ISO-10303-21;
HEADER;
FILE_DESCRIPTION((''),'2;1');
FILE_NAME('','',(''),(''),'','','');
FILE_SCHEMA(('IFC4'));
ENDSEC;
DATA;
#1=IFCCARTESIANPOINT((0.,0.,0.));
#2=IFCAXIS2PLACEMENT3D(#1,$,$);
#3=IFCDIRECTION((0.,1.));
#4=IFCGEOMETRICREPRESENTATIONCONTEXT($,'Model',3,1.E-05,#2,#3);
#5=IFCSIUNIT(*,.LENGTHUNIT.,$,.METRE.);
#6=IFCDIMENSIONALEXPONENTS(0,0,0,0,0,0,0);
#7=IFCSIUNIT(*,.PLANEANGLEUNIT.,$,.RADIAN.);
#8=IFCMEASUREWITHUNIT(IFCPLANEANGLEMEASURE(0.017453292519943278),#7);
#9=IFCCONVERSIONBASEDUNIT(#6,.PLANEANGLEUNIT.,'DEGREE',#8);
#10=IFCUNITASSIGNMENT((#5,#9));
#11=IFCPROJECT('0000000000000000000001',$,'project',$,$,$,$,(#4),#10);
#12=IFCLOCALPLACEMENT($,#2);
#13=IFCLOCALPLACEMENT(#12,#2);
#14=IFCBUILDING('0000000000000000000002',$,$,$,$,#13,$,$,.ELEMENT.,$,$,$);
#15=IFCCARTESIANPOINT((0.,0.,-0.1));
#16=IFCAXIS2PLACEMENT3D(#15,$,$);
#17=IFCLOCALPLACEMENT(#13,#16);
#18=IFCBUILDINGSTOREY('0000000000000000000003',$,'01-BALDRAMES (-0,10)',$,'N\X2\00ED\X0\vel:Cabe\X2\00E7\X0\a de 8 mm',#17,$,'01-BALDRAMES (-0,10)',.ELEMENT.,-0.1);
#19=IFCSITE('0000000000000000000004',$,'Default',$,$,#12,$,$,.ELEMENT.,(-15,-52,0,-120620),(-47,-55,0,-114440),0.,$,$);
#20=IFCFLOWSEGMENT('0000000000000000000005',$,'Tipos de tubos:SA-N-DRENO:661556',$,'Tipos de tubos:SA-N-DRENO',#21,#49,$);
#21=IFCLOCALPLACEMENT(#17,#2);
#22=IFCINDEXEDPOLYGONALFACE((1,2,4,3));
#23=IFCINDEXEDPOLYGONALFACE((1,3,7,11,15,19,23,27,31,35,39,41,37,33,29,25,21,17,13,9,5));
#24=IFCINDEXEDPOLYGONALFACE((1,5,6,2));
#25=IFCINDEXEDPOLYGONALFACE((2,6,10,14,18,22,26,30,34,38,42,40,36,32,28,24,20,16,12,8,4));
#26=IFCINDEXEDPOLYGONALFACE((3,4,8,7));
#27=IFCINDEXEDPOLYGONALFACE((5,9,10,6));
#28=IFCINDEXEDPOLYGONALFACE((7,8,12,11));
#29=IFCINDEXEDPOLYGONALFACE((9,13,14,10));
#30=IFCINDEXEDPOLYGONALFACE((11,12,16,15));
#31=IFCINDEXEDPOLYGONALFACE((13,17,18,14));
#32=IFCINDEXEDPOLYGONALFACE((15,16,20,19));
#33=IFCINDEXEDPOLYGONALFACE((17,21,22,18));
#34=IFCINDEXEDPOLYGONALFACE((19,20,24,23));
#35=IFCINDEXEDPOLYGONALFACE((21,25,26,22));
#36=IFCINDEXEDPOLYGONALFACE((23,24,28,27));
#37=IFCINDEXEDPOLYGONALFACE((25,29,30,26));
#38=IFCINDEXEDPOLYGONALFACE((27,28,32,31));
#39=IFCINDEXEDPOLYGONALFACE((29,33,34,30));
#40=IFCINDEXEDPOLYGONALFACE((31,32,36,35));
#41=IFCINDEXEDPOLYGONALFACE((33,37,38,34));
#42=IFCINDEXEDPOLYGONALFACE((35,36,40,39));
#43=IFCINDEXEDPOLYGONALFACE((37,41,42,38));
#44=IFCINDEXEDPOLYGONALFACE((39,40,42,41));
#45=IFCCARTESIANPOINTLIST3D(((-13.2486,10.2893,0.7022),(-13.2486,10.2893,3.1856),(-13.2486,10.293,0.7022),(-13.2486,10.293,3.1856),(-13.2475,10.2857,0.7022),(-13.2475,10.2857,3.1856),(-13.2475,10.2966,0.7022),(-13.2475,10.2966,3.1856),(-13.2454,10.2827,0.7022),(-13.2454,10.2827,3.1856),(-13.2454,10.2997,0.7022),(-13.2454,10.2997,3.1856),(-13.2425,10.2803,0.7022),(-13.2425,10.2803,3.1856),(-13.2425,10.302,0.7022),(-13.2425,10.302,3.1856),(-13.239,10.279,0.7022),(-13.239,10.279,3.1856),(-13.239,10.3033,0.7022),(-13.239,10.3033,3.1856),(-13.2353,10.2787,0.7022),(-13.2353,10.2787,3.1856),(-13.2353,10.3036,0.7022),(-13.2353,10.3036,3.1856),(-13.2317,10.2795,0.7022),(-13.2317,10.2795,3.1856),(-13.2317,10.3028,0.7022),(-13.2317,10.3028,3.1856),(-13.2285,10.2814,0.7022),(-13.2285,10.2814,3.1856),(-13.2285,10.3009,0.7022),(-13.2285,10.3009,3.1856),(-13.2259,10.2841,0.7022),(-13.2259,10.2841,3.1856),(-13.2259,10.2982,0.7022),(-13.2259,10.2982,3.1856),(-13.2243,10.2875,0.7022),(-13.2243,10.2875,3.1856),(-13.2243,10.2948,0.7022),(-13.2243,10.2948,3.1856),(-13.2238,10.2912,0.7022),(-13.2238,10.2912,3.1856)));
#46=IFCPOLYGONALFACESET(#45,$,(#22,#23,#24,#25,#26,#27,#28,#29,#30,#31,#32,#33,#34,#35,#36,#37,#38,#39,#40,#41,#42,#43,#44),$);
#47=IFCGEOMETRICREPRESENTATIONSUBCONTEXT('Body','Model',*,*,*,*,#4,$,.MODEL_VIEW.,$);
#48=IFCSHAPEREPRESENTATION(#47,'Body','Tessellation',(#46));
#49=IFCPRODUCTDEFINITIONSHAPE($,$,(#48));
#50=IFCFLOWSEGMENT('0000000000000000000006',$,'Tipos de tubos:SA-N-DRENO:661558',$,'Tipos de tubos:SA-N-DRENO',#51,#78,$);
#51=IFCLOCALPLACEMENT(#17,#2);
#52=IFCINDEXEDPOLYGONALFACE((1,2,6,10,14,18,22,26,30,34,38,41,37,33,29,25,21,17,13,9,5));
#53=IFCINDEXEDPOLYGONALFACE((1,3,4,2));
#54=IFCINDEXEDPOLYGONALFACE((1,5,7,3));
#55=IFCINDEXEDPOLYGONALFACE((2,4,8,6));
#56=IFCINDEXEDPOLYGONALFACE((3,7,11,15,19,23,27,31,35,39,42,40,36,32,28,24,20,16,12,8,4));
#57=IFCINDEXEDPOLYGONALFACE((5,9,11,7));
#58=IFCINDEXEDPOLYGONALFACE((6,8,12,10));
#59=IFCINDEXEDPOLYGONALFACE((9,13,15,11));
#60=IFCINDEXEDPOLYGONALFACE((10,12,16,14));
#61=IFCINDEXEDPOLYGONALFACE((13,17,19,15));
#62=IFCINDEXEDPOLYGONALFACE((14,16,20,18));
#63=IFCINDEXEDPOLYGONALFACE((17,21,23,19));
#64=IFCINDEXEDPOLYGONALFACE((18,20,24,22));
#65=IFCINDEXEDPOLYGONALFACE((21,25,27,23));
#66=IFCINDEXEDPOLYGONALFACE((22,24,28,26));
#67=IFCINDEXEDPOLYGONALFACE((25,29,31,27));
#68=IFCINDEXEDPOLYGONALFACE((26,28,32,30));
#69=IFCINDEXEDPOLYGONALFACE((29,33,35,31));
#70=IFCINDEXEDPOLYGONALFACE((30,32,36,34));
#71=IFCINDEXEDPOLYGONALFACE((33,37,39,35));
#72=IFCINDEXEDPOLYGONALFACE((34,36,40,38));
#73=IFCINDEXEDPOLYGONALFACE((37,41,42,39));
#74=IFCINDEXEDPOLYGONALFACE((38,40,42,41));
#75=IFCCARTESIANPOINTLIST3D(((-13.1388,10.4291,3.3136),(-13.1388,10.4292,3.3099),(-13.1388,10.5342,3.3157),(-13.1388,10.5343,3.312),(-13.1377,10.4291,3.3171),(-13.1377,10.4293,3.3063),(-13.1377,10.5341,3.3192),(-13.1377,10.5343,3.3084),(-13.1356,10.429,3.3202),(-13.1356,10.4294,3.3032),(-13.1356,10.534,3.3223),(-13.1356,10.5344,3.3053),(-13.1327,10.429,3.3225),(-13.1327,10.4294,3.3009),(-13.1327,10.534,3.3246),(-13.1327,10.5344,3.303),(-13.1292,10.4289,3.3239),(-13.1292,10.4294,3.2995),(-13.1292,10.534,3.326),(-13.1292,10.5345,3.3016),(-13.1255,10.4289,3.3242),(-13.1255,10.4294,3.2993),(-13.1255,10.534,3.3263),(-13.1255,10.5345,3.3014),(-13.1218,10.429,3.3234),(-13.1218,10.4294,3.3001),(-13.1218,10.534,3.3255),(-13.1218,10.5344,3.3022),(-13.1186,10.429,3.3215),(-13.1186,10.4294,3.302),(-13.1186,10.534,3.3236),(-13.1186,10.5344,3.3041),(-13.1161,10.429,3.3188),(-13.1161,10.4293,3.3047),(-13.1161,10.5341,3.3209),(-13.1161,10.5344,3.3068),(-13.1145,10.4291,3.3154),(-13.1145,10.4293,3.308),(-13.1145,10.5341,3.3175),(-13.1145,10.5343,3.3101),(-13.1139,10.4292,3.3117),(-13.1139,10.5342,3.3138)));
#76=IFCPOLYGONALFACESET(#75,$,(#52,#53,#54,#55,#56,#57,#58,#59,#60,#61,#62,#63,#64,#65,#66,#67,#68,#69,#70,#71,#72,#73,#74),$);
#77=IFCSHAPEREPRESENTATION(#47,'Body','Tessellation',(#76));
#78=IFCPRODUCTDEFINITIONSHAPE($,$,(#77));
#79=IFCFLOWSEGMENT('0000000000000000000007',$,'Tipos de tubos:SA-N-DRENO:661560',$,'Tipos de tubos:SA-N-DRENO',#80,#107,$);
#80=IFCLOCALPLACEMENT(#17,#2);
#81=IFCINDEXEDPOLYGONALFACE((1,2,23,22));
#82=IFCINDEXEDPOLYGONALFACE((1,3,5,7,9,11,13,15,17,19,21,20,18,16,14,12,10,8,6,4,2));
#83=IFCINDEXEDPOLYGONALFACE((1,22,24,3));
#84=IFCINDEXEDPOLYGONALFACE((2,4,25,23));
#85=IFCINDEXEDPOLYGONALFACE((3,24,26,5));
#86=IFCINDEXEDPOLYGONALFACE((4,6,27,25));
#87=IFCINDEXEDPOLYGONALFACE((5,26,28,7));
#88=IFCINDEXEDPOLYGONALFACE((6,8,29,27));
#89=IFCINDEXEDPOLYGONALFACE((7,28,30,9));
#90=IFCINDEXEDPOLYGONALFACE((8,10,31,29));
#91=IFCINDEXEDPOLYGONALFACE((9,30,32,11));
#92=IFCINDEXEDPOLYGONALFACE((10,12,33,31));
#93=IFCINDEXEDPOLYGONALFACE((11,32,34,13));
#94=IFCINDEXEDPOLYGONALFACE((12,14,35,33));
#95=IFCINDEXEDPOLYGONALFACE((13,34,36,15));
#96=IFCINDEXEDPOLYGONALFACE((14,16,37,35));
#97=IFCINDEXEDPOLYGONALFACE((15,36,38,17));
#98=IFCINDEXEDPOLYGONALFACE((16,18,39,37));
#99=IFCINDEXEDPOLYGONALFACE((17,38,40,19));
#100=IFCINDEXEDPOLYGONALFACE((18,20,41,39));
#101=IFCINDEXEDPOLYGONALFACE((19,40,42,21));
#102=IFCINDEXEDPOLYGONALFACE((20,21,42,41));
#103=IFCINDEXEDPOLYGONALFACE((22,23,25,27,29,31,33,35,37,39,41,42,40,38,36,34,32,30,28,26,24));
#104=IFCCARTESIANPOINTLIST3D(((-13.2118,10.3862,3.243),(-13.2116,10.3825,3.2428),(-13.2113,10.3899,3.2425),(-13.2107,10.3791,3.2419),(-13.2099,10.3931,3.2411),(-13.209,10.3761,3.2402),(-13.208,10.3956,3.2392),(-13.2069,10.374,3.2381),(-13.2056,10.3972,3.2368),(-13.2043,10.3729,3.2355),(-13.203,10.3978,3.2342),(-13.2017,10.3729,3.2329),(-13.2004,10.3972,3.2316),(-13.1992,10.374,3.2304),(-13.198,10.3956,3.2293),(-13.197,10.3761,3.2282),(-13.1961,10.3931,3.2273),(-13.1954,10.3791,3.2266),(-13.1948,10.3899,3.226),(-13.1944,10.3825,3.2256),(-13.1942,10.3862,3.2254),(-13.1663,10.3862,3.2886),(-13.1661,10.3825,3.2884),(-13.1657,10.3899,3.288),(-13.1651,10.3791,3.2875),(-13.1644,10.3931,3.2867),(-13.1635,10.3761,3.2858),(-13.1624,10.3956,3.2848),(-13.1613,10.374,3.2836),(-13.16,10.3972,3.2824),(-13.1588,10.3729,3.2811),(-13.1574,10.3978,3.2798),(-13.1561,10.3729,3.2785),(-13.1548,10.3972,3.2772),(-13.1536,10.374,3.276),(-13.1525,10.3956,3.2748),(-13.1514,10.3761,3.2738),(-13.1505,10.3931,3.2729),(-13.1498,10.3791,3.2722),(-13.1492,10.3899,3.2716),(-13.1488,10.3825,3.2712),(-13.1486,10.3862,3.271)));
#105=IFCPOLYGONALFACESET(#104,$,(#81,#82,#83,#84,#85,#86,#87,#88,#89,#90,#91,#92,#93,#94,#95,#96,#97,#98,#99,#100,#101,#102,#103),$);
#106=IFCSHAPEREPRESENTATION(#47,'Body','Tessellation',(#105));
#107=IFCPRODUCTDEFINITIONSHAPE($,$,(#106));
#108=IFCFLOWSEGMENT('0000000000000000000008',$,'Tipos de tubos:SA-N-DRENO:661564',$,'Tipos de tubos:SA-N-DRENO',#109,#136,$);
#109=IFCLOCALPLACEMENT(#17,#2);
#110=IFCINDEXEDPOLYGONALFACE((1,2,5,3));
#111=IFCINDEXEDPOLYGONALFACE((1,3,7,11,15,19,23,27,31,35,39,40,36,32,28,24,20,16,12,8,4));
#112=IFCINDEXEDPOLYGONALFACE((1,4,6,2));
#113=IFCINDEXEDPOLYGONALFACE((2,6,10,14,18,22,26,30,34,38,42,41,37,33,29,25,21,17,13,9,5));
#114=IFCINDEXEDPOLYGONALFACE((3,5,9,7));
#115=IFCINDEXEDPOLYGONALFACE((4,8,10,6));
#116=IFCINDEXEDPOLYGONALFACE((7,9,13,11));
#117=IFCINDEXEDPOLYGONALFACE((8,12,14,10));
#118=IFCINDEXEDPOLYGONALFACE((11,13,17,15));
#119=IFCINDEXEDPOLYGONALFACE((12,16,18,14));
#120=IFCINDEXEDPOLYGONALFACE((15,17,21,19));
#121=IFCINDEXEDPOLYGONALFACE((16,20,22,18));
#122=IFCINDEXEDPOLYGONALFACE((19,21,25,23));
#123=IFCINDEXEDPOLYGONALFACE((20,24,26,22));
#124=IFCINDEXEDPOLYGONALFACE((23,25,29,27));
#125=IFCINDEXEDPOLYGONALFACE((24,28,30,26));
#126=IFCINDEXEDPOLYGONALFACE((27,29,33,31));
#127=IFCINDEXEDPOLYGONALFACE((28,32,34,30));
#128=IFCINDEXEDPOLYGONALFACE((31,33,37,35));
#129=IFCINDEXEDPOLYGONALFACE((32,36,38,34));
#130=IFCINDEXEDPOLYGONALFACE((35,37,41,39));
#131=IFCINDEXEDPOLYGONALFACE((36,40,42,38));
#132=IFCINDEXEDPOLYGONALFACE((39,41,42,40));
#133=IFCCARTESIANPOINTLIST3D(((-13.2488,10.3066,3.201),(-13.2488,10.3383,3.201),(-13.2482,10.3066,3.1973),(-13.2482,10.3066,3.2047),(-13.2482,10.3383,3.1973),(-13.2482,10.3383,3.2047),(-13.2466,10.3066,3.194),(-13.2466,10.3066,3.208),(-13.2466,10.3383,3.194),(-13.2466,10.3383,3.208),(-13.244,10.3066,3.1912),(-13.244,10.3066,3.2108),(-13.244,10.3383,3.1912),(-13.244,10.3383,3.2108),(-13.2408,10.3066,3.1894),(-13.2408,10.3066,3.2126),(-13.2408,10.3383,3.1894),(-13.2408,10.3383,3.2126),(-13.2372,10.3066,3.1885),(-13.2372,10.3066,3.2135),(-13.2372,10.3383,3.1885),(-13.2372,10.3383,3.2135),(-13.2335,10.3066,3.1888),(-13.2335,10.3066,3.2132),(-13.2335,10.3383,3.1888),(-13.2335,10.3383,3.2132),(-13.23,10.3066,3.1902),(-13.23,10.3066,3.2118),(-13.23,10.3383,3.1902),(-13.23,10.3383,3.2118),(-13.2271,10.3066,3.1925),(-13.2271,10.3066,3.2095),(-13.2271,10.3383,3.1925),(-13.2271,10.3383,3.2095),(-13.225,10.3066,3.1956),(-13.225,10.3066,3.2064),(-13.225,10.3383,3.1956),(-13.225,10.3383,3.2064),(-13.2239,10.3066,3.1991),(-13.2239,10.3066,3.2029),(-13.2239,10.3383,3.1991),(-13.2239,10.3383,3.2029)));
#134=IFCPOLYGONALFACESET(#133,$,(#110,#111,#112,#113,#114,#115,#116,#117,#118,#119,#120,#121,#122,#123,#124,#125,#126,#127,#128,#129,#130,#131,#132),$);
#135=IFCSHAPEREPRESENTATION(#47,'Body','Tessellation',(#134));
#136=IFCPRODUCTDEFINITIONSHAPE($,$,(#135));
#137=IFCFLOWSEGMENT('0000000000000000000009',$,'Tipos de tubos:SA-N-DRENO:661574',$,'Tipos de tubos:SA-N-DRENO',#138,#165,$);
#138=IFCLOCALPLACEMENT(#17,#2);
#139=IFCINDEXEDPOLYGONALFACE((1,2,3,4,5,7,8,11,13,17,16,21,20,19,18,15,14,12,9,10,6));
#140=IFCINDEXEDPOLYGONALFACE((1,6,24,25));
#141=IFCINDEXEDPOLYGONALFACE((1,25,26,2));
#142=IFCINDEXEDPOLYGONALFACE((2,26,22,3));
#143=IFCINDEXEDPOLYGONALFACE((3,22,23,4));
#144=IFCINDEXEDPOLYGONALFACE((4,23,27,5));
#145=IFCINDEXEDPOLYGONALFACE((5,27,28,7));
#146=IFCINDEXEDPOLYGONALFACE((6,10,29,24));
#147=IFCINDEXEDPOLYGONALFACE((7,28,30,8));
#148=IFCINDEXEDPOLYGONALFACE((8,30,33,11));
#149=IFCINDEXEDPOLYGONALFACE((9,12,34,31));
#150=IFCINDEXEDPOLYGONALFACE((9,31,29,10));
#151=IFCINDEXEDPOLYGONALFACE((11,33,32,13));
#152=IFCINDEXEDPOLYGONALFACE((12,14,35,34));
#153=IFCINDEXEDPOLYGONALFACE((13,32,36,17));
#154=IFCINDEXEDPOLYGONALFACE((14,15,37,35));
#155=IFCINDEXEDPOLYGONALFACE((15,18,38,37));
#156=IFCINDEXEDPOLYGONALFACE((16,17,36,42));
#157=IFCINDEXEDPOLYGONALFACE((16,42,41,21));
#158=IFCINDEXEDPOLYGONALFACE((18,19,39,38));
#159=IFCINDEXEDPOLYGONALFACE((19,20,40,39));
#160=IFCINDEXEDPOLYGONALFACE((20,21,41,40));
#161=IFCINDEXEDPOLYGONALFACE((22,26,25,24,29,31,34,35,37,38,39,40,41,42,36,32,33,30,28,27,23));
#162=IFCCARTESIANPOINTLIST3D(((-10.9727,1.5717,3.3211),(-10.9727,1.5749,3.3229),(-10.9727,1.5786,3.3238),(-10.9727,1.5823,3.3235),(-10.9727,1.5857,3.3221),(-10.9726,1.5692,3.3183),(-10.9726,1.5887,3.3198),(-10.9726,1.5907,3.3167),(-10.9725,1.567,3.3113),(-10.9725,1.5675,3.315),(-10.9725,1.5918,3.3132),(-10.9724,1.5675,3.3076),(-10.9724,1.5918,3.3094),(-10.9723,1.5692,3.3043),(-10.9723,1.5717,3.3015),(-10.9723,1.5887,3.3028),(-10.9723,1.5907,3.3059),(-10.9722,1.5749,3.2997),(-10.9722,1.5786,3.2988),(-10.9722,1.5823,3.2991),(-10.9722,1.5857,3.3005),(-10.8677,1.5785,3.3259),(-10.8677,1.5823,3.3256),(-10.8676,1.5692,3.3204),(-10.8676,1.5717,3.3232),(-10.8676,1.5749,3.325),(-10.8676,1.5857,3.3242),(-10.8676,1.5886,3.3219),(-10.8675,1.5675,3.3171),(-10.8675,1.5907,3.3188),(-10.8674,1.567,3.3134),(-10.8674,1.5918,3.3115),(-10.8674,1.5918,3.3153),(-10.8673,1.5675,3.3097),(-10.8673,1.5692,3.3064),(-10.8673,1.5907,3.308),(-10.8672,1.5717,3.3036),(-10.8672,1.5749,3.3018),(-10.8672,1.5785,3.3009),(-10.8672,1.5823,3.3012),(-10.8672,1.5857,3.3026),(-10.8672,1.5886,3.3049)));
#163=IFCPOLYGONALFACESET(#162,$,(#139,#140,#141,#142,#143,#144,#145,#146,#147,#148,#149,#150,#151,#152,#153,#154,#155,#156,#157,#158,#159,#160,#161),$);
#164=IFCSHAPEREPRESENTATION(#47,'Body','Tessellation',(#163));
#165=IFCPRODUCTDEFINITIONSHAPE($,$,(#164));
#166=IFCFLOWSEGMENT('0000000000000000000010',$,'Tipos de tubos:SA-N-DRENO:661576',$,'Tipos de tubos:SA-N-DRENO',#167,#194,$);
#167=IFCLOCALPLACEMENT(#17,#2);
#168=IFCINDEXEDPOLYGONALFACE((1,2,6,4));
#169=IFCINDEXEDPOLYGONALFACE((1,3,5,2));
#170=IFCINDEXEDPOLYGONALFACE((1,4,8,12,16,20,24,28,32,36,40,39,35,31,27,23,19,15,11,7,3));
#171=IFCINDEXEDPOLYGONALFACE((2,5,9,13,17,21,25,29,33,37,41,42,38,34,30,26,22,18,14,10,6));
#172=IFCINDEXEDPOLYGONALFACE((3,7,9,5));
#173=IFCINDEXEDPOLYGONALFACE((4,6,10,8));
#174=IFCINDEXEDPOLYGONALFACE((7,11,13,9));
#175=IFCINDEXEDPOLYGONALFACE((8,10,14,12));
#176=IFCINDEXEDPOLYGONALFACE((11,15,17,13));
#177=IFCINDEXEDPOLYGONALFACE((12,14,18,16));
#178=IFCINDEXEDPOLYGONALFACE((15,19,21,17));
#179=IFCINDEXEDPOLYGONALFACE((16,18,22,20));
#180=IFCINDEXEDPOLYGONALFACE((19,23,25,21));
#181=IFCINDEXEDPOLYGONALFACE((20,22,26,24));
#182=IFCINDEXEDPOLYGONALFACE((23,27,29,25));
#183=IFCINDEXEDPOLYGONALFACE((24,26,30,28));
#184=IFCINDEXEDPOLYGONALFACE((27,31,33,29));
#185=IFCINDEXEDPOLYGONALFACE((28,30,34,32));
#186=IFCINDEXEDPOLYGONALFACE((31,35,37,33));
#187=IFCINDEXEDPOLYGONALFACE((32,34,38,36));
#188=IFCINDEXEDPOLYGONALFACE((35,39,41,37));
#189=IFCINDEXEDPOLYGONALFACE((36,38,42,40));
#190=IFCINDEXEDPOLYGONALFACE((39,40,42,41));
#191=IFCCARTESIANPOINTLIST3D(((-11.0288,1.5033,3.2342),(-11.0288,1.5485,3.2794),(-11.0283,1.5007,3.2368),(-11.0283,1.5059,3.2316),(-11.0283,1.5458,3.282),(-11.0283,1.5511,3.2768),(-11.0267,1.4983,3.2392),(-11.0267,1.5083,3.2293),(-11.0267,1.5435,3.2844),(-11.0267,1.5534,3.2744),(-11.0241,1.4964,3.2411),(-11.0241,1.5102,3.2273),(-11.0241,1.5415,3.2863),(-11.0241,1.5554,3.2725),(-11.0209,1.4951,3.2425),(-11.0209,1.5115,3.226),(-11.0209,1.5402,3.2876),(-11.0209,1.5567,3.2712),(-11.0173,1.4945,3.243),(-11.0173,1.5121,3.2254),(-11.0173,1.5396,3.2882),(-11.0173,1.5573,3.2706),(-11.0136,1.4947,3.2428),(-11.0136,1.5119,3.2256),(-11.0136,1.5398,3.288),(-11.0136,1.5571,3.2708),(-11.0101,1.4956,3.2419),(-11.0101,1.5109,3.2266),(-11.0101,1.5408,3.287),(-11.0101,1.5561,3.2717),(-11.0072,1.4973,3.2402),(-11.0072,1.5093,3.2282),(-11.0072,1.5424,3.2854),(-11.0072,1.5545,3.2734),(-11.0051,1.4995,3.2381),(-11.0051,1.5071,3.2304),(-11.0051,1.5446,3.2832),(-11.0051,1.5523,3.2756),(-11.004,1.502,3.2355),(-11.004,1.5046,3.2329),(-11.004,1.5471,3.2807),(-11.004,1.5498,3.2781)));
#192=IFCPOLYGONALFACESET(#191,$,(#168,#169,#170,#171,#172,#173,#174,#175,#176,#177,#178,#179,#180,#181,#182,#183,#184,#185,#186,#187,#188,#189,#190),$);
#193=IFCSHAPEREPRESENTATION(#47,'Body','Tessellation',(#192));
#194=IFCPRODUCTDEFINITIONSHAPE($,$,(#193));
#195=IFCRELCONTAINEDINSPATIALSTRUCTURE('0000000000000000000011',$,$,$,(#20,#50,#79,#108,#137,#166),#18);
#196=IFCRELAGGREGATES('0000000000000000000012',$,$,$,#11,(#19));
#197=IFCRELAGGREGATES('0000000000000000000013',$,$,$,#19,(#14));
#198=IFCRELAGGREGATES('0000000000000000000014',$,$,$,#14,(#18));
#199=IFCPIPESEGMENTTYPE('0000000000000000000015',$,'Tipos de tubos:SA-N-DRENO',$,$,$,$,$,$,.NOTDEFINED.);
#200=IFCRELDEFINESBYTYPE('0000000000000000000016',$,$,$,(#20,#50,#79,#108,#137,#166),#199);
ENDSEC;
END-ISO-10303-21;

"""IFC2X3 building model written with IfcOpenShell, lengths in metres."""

from ifc_helpers import new_model, entity, si_unit, converted_unit, direction, frame, frame_2d, origin, origin_2d_with_axis, place, context, subcontext, project, spatial, circle, extrude, type_object, element, save


model = new_model("IFC2X3")

# Units and contexts
model_context = context("Model", 3, precision=1e-05, world=origin(), true_north=direction((0.0, 1.0)))
body_context = subcontext(model_context, "Body", "Model", "MODEL_VIEW")
ifc_project = project(units=[si_unit("LENGTHUNIT", "METRE"), converted_unit("PLANEANGLEUNIT", "DEGREE", entity("IfcPlaneAngleMeasure", 0.017453292519943278), si_unit("PLANEANGLEUNIT", "RADIAN"), dimensions=[0, 0, 0, 0, 0, 0, 0])], contexts=[model_context])

# Site, building, storey
site_placement = place(None, origin())
site = spatial("IfcSite", under=ifc_project, at=site_placement, Name="Default", CompositionType="ELEMENT", RefLatitude=(-15, -52, 0, -120620), RefLongitude=(-47, -55, 0, -114440), RefElevation=0.0)
building_placement = place(site_placement, origin())
building = spatial("IfcBuilding", under=site, at=building_placement, CompositionType="ELEMENT")
storey_placement = place(building_placement, frame((0.0, 0.0, -0.1)))
storey = spatial("IfcBuildingStorey", under=building, at=storey_placement, Name="01-BALDRAMES (-0,10)", ObjectType="Nível:Cabeça de 8 mm", LongName="01-BALDRAMES (-0,10)", CompositionType="ELEMENT", Elevation=-0.1)

# Flow segments
pipe_segment_type_1 = type_object("IfcPipeSegmentType", Name="Tipos de tubos:SA-N-DRENO", PredefinedType="NOTDEFINED")
flow_segment_1_placement = place(storey_placement, origin())
element("IfcFlowSegment", 1, at=flow_segment_1_placement, inside=storey, type_object=pipe_segment_type_1, Name="Tipos de tubos:SA-N-DRENO:661556", ObjectType="Tipos de tubos:SA-N-DRENO", context=body_context, shape_type="SweptSolid", body=[
    extrude(circle(Radius=0.0125, at=frame_2d((0.0, 0.0), x_axis=(1.0, 0.0))), frame((-13.2363, 10.2912, 0.7022)), (0.0, 0.0, 1.0), 2.4834),
])
flow_segment_2_placement = place(storey_placement, origin())
element("IfcFlowSegment", 2, at=flow_segment_2_placement, inside=storey, type_object=pipe_segment_type_1, Name="Tipos de tubos:SA-N-DRENO:661558", ObjectType="Tipos de tubos:SA-N-DRENO", context=body_context, shape_type="SweptSolid", body=[
    extrude(circle(Radius=0.0125, at=origin_2d_with_axis()), frame((-13.1264, 10.4292, 3.3117), z_axis=(-0.000001, 0.9998, 0.019996), x_axis=(1.0, 0.000001, 0.0)), (0.0, 0.0, 1.0), 0.1051),
])
flow_segment_3_placement = place(storey_placement, origin())
element("IfcFlowSegment", 3, at=flow_segment_3_placement, inside=storey, type_object=pipe_segment_type_1, Name="Tipos de tubos:SA-N-DRENO:661560", ObjectType="Tipos de tubos:SA-N-DRENO", context=body_context, shape_type="SweptSolid", body=[
    extrude(circle(Radius=0.0125, at=origin_2d_with_axis()), frame((-13.203, 10.3853, 3.2342), z_axis=(0.707107, 0.000001, 0.707107), x_axis=(-0.000001, 1.0, 0.0)), (0.0, 0.0, 1.0), 0.0645),
])
flow_segment_4_placement = place(storey_placement, origin())
element("IfcFlowSegment", 4, at=flow_segment_4_placement, inside=storey, type_object=pipe_segment_type_1, Name="Tipos de tubos:SA-N-DRENO:661564", ObjectType="Tipos de tubos:SA-N-DRENO", context=body_context, shape_type="SweptSolid", body=[
    extrude(circle(Radius=0.0125, at=origin_2d_with_axis()), frame((-13.2363, 10.3066, 3.201), z_axis=(-0.000001, 1.0, 0.0), x_axis=(-1.0, -0.000001, 0.0)), (0.0, 0.0, 1.0), 0.0318),
])
flow_segment_5_placement = place(storey_placement, origin())
element("IfcFlowSegment", 5, at=flow_segment_5_placement, inside=storey, type_object=pipe_segment_type_1, Name="Tipos de tubos:SA-N-DRENO:661574", ObjectType="Tipos de tubos:SA-N-DRENO", context=body_context, shape_type="SweptSolid", body=[
    extrude(circle(Radius=0.0125, at=origin_2d_with_axis()), frame((-10.9725, 1.5795, 3.3113), z_axis=(0.9998, -0.000041, 0.019996), x_axis=(-0.000041, -1.0, 0.0)), (0.0, 0.0, 1.0), 0.1051),
])
flow_segment_6_placement = place(storey_placement, origin())
element("IfcFlowSegment", 6, at=flow_segment_6_placement, inside=storey, type_object=pipe_segment_type_1, Name="Tipos de tubos:SA-N-DRENO:661576", ObjectType="Tipos de tubos:SA-N-DRENO", context=body_context, shape_type="SweptSolid", body=[
    extrude(circle(Radius=0.0125, at=origin_2d_with_axis()), frame((-11.0163, 1.5033, 3.2342), z_axis=(0.000029, 0.707107, 0.707107), x_axis=(-1.0, 0.000041, 0.0)), (0.0, 0.0, 1.0), 0.0639),
])

save(model, "model.ifc")
